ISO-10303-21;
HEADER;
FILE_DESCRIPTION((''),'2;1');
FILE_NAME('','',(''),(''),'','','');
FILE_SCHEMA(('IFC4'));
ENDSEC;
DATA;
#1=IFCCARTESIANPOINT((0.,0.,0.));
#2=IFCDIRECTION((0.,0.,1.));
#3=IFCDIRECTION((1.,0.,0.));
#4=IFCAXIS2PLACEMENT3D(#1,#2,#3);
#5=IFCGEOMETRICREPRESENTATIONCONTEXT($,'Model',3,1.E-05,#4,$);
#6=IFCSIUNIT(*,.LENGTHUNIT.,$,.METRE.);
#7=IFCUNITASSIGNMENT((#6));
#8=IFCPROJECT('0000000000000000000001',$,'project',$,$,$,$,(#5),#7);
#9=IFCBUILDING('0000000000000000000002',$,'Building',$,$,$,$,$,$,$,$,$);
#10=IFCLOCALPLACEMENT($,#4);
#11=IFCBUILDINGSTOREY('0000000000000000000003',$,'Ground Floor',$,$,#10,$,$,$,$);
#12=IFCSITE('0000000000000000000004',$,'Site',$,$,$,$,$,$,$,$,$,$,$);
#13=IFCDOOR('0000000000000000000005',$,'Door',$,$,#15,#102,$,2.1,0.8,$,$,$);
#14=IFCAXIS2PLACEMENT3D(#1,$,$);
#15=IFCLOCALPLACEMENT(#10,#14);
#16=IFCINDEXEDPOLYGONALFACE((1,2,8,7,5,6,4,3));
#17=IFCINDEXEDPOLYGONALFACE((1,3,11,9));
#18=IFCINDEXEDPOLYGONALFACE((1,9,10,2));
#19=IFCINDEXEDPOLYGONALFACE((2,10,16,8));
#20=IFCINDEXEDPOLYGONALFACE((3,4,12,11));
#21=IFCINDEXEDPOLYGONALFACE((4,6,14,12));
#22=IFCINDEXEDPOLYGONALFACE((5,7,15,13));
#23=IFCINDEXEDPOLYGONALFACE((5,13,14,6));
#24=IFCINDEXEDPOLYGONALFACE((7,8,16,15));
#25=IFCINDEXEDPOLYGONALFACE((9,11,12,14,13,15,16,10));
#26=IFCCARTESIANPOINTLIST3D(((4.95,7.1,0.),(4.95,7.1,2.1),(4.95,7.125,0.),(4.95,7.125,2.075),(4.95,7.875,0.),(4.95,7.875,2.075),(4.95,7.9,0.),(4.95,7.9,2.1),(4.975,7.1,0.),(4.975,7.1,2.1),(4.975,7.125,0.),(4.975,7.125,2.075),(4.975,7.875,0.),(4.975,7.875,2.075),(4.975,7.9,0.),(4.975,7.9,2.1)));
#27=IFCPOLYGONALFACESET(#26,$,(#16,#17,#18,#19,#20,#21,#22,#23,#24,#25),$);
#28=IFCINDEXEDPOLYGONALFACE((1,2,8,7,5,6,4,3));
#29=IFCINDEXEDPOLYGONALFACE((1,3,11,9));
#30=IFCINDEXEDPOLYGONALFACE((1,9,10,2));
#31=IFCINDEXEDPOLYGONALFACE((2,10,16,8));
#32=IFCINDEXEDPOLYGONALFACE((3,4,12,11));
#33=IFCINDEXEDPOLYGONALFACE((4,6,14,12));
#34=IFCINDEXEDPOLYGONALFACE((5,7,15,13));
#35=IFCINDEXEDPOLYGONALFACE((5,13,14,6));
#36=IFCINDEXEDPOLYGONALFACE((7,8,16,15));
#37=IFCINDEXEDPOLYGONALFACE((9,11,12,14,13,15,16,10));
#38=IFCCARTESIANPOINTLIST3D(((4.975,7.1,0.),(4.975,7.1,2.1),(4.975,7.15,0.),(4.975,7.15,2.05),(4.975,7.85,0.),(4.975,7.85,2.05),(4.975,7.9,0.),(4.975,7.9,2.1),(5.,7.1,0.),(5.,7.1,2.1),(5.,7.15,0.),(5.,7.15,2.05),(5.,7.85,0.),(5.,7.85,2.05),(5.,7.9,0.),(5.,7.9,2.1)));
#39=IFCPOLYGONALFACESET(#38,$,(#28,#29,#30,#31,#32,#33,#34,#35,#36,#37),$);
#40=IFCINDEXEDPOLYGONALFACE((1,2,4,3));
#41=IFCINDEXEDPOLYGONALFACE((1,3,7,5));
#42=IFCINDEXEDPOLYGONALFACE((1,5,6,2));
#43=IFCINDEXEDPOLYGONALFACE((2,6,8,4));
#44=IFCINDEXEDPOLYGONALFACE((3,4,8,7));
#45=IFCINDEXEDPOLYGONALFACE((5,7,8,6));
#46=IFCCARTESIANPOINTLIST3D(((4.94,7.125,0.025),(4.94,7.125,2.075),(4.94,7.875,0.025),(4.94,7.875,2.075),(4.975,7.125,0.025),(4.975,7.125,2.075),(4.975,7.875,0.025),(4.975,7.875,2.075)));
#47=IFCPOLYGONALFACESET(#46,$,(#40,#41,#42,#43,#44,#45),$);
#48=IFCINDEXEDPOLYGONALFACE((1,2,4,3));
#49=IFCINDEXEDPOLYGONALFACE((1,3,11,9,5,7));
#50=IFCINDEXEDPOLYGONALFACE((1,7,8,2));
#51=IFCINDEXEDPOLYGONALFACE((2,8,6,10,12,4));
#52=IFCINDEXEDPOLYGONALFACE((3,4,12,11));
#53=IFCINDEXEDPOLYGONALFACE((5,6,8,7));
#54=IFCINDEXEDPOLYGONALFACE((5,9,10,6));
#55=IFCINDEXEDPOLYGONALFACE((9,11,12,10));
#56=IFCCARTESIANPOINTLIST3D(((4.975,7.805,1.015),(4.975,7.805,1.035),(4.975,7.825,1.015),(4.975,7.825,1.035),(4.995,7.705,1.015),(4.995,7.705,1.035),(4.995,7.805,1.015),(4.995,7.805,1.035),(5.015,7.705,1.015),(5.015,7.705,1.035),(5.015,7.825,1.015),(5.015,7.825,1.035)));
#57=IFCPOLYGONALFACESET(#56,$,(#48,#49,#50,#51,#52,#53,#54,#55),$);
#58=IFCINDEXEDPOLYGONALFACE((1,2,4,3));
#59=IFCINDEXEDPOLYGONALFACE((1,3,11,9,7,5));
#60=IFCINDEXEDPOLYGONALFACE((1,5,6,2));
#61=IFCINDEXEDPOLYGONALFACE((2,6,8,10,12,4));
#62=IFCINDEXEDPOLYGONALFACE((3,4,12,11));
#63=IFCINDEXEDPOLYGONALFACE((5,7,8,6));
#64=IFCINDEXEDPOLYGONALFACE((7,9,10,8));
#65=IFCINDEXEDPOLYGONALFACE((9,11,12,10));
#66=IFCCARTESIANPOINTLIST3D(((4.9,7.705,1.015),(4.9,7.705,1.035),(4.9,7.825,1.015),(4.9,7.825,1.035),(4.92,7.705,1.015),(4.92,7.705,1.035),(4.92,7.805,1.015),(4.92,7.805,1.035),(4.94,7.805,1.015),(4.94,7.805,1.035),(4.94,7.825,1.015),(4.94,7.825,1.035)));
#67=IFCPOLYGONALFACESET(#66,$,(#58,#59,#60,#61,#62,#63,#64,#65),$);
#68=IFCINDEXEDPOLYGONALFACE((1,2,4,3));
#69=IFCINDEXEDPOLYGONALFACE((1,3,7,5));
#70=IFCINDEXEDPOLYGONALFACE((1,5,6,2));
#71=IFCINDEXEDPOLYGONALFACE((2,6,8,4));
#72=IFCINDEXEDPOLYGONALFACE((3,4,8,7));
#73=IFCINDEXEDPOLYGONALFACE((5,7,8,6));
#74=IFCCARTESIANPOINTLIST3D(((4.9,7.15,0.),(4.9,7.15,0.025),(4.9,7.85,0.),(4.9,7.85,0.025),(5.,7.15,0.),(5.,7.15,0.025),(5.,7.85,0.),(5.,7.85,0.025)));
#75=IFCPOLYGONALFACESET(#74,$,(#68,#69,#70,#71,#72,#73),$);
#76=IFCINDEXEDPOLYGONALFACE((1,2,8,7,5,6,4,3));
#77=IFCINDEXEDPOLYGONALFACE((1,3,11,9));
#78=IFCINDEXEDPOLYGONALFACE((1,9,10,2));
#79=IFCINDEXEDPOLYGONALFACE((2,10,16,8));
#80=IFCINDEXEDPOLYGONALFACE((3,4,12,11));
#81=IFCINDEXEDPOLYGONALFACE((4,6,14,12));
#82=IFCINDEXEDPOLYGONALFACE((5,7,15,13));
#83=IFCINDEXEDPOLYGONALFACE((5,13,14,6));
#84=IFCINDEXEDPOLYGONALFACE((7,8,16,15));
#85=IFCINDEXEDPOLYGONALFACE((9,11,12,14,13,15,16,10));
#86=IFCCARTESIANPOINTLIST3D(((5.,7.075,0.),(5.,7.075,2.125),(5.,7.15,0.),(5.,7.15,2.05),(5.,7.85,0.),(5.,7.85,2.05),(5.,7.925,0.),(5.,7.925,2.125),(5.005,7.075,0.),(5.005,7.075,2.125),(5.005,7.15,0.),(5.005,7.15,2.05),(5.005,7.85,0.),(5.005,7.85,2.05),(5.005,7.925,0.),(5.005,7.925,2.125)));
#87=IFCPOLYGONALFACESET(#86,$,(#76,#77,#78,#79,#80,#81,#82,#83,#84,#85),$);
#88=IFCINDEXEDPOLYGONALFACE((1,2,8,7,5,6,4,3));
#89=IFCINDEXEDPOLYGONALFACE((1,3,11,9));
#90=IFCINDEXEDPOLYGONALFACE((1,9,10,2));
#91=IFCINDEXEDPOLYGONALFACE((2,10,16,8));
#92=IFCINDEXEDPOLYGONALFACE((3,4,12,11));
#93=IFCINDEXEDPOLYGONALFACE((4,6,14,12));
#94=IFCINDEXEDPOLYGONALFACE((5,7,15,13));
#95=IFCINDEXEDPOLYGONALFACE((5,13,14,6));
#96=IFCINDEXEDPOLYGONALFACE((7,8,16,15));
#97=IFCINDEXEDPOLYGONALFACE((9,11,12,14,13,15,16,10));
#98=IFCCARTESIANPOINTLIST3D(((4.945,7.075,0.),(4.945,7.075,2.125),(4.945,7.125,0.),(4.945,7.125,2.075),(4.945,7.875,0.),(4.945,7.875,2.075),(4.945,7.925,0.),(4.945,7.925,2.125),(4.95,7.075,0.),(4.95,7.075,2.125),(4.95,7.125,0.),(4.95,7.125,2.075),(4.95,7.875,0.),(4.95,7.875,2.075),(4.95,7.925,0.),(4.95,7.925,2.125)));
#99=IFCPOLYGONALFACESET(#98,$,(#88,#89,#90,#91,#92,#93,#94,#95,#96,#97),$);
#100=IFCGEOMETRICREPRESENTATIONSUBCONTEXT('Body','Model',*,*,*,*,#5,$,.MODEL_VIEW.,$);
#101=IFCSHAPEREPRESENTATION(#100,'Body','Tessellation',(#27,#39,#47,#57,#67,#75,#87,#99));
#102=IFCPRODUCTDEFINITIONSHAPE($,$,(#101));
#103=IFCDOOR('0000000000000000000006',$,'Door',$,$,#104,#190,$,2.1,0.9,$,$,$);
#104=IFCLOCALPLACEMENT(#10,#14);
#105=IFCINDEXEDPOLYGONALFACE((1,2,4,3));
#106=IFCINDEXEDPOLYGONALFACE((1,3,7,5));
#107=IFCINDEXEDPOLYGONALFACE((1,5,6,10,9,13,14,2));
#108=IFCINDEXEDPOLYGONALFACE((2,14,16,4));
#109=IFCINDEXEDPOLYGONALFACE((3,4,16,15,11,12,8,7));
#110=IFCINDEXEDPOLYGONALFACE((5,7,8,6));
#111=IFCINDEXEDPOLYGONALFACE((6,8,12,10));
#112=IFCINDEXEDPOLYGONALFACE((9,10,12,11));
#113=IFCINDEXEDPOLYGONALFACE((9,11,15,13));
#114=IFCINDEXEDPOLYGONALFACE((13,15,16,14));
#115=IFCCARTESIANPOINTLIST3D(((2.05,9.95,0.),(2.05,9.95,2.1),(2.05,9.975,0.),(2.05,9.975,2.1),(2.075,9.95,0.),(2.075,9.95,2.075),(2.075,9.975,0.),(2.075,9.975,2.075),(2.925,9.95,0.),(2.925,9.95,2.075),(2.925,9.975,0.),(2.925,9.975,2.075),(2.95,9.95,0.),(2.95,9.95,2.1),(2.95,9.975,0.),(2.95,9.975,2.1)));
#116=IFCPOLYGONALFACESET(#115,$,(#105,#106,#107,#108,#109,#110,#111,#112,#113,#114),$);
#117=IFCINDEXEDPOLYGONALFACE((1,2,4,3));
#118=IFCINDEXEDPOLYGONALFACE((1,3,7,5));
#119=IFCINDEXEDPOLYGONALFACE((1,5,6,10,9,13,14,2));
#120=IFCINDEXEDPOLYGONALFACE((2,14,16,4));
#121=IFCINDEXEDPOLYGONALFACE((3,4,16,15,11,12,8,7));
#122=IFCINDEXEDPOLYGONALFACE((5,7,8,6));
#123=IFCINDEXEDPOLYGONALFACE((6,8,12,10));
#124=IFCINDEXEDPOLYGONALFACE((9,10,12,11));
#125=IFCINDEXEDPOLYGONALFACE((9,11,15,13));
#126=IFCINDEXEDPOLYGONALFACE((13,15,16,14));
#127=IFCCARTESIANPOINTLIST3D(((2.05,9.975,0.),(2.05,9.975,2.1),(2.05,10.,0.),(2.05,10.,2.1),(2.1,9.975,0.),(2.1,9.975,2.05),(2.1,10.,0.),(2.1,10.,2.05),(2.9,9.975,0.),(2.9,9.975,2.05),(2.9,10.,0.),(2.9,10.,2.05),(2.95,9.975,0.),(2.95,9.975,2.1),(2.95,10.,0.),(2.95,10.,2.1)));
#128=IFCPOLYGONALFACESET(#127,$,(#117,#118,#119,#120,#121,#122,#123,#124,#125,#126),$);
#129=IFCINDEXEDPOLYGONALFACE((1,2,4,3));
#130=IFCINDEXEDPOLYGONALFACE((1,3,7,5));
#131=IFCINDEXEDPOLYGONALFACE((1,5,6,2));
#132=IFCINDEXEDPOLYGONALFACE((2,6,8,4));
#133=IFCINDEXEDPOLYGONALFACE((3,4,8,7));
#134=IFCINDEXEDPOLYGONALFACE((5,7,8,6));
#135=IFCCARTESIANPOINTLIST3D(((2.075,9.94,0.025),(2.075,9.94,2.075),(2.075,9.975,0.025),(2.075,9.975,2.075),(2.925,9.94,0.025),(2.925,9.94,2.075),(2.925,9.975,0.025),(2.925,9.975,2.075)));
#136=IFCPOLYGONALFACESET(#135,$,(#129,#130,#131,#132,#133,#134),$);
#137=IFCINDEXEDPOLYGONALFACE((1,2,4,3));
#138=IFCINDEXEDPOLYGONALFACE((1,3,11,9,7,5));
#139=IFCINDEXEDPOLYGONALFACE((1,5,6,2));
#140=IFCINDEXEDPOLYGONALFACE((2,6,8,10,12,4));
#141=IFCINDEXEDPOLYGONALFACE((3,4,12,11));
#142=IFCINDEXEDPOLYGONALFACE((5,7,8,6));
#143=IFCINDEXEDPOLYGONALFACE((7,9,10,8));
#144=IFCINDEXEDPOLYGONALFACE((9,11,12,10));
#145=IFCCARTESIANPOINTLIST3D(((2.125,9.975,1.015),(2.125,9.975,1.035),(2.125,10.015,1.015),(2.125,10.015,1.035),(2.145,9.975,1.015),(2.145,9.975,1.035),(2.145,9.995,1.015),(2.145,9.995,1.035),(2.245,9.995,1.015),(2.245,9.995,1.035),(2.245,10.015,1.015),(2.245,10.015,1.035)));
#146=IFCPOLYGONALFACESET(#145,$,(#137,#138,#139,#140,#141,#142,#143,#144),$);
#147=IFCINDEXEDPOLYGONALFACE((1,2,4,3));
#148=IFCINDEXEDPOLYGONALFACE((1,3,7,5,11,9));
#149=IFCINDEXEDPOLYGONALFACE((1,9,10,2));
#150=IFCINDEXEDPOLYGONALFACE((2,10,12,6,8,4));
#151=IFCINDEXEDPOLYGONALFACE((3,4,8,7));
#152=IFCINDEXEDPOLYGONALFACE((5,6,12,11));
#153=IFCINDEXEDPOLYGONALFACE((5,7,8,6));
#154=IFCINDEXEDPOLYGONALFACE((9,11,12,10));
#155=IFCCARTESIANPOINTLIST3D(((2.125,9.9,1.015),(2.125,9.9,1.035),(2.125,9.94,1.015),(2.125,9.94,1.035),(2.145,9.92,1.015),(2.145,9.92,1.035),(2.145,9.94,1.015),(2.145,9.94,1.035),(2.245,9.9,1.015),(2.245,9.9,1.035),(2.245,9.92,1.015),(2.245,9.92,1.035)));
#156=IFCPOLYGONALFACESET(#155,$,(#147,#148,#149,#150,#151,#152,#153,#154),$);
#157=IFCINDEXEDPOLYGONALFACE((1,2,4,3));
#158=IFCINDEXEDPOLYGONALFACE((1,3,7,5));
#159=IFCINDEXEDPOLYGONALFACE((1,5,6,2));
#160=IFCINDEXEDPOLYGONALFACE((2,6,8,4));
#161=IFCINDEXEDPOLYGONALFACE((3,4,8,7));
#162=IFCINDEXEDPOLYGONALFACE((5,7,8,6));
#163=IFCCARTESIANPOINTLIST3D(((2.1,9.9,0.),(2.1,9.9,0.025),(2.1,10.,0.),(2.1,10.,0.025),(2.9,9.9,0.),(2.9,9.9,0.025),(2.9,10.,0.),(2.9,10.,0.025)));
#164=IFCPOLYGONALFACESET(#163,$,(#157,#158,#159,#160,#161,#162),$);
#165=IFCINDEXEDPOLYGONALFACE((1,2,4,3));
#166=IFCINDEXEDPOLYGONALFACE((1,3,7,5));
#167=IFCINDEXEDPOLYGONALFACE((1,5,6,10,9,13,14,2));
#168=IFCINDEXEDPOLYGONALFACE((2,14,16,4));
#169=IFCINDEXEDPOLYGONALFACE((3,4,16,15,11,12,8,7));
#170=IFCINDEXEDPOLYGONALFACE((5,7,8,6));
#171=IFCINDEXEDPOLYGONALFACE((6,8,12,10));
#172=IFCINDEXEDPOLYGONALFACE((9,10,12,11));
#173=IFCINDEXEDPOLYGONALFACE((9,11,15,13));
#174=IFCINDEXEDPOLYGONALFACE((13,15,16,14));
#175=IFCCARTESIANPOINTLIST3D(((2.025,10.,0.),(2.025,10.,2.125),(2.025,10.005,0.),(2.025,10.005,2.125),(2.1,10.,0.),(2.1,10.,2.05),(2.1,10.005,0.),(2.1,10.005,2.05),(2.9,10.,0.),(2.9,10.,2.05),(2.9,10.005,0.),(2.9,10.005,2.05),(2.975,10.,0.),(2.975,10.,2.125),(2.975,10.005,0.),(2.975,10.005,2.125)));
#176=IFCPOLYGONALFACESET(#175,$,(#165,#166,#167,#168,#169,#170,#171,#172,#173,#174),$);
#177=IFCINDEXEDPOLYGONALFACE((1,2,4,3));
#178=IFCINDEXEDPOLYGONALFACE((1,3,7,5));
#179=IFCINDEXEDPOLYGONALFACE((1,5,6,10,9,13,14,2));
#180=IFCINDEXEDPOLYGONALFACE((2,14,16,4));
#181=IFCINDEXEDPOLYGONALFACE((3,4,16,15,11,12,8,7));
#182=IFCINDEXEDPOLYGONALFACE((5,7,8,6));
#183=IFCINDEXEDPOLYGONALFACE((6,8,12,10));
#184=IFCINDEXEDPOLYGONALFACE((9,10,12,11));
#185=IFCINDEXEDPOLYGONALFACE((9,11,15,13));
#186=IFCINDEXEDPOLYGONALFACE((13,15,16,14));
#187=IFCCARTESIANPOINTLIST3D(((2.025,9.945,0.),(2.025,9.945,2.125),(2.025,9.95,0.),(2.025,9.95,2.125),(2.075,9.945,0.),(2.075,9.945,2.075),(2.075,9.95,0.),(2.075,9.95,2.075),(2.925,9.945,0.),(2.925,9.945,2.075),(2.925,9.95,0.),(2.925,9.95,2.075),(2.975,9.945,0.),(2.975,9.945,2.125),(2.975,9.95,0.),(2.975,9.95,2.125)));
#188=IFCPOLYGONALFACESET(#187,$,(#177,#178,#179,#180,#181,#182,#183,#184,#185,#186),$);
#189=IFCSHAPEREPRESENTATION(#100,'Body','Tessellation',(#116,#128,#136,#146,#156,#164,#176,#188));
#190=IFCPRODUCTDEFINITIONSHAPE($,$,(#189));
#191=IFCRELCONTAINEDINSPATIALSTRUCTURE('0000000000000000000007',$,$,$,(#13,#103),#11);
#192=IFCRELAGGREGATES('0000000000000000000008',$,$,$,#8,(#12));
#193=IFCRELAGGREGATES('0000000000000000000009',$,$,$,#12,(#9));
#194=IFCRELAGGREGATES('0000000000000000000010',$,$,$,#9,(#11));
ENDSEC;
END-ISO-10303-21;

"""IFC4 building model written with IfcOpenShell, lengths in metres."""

from ifc_helpers import new_model, si_unit, frame, origin_with_axes, place, context, subcontext, project, spatial, line, indexed_curve, outline, extrude, element, save


model = new_model("IFC4")

# Units and contexts
model_context = context("Model", 3, precision=1e-05, world=origin_with_axes())
body_context = subcontext(model_context, "Body", "Model", "MODEL_VIEW")
ifc_project = project(units=[si_unit("LENGTHUNIT", "METRE")], contexts=[model_context])

# Site, building, storey
site = spatial("IfcSite", under=ifc_project, Name="Site")
building = spatial("IfcBuilding", under=site, Name="Building")
storey_placement = place(None, origin_with_axes())
storey = spatial("IfcBuildingStorey", under=building, at=storey_placement, Name="Ground Floor")

# Doors
door_1_placement = place(storey_placement, frame((5.0, 7.1, 0.0), z_axis=(0.0, 0.0, 1.0), x_axis=(0.0, 1.0, 0.0)))
element("IfcDoor", 1, at=door_1_placement, inside=storey, Name="Door", OverallHeight=2.1, OverallWidth=0.8, context=body_context, shape_type="SweptSolid", body=[
    extrude(outline(indexed_curve([(0.0, 0.0), (0.0, 2.1), (0.8, 2.1), (0.8, 0.0), (0.775, 0.0), (0.775, 2.075), (0.025, 2.075), (0.025, 0.0)], segments=[line(1, 2, 3, 4, 5, 6, 7, 8, 1)])), frame((0.0, 0.025, 0.0), z_axis=(0.0, -1.0, 0.0), x_axis=(1.0, 0.0, 0.0)), (0.0, 0.0, -1.0), 0.025),
    extrude(outline(indexed_curve([(0.0, 0.0), (0.0, 2.1), (0.8, 2.1), (0.8, 0.0), (0.75, 0.0), (0.75, 2.05), (0.05, 2.05), (0.05, 0.0)], segments=[line(1, 2, 3, 4, 5, 6, 7, 8, 1)])), frame((0.0, 0.0, 0.0), z_axis=(0.0, -1.0, 0.0), x_axis=(1.0, 0.0, 0.0)), (0.0, 0.0, -1.0), 0.025),
    extrude(outline(indexed_curve([(0.0, 0.0), (0.75, 0.0), (0.75, 0.035), (0.0, 0.035)], segments=[line(1, 2, 3, 4, 1)])), frame((0.025, 0.025, 0.025), z_axis=(0.0, 0.0, 1.0), x_axis=(1.0, 0.0, 0.0)), (0.0, 0.0, 1.0), 2.05),
    extrude(outline(indexed_curve([(0.0, 0.0), (0.0, -0.04), (-0.12, -0.04), (-0.12, -0.02), (-0.02, -0.02), (-0.02, 0.0)], segments=[line(1, 2, 3, 4, 5, 6, 1)])), frame((0.725, 0.025, 1.015), z_axis=(0.0, 0.0, 1.0), x_axis=(1.0, 0.0, 0.0)), (0.0, 0.0, 1.0), 0.02),
    extrude(outline(indexed_curve([(0.0, 0.0), (0.0, 0.04), (-0.12, 0.04), (-0.12, 0.02), (-0.02, 0.02), (-0.02, 0.0)], segments=[line(1, 2, 3, 4, 5, 6, 1)])), frame((0.725, 0.06, 1.015), z_axis=(0.0, 0.0, 1.0), x_axis=(1.0, 0.0, 0.0)), (0.0, 0.0, 1.0), 0.02),
    extrude(outline(indexed_curve([(0.0, 0.0), (0.7, 0.0), (0.7, 0.1), (0.0, 0.1)], segments=[line(1, 2, 3, 4, 1)])), frame((0.05, 0.0, 0.0), z_axis=(0.0, 0.0, 1.0), x_axis=(1.0, 0.0, 0.0)), (0.0, 0.0, 1.0), 0.025),
    extrude(outline(indexed_curve([(0.0, 0.0), (0.0, 2.125), (0.85, 2.125), (0.85, 0.0), (0.775, 0.0), (0.775, 2.05), (0.075, 2.05), (0.075, 0.0)], segments=[line(1, 2, 3, 4, 5, 6, 7, 8, 1)])), frame((-0.025, -0.005, 0.0), z_axis=(0.0, -1.0, 0.0), x_axis=(1.0, 0.0, 0.0)), (0.0, 0.0, -1.0), 0.005),
    extrude(outline(indexed_curve([(0.0, 0.0), (0.0, 2.125), (0.85, 2.125), (0.85, 0.0), (0.8, 0.0), (0.8, 2.075), (0.05, 2.075), (0.05, 0.0)], segments=[line(1, 2, 3, 4, 5, 6, 7, 8, 1)])), frame((-0.025, 0.05, 0.0), z_axis=(0.0, -1.0, 0.0), x_axis=(1.0, 0.0, 0.0)), (0.0, 0.0, -1.0), 0.005),
])
door_2_placement = place(storey_placement, frame((2.95, 10.0, 0.0), z_axis=(0.0, 0.0, 1.0), x_axis=(-1.0, 0.0, 0.0)))
element("IfcDoor", 2, at=door_2_placement, inside=storey, Name="Door", OverallHeight=2.1, OverallWidth=0.9, context=body_context, shape_type="SweptSolid", body=[
    extrude(outline(indexed_curve([(0.0, 0.0), (0.0, 2.1), (0.9, 2.1), (0.9, 0.0), (0.875, 0.0), (0.875, 2.075), (0.025, 2.075), (0.025, 0.0)], segments=[line(1, 2, 3, 4, 5, 6, 7, 8, 1)])), frame((0.0, 0.025, 0.0), z_axis=(0.0, -1.0, 0.0), x_axis=(1.0, 0.0, 0.0)), (0.0, 0.0, -1.0), 0.025),
    extrude(outline(indexed_curve([(0.0, 0.0), (0.0, 2.1), (0.9, 2.1), (0.9, 0.0), (0.85, 0.0), (0.85, 2.05), (0.05, 2.05), (0.05, 0.0)], segments=[line(1, 2, 3, 4, 5, 6, 7, 8, 1)])), frame((0.0, 0.0, 0.0), z_axis=(0.0, -1.0, 0.0), x_axis=(1.0, 0.0, 0.0)), (0.0, 0.0, -1.0), 0.025),
    extrude(outline(indexed_curve([(0.0, 0.0), (0.85, 0.0), (0.85, 0.035), (0.0, 0.035)], segments=[line(1, 2, 3, 4, 1)])), frame((0.025, 0.025, 0.025), z_axis=(0.0, 0.0, 1.0), x_axis=(1.0, 0.0, 0.0)), (0.0, 0.0, 1.0), 2.05),
    extrude(outline(indexed_curve([(0.0, 0.0), (0.0, -0.04), (-0.12, -0.04), (-0.12, -0.02), (-0.02, -0.02), (-0.02, 0.0)], segments=[line(1, 2, 3, 4, 5, 6, 1)])), frame((0.825, 0.025, 1.015), z_axis=(0.0, 0.0, 1.0), x_axis=(1.0, 0.0, 0.0)), (0.0, 0.0, 1.0), 0.02),
    extrude(outline(indexed_curve([(0.0, 0.0), (0.0, 0.04), (-0.12, 0.04), (-0.12, 0.02), (-0.02, 0.02), (-0.02, 0.0)], segments=[line(1, 2, 3, 4, 5, 6, 1)])), frame((0.825, 0.06, 1.015), z_axis=(0.0, 0.0, 1.0), x_axis=(1.0, 0.0, 0.0)), (0.0, 0.0, 1.0), 0.02),
    extrude(outline(indexed_curve([(0.0, 0.0), (0.8, 0.0), (0.8, 0.1), (0.0, 0.1)], segments=[line(1, 2, 3, 4, 1)])), frame((0.05, 0.0, 0.0), z_axis=(0.0, 0.0, 1.0), x_axis=(1.0, 0.0, 0.0)), (0.0, 0.0, 1.0), 0.025),
    extrude(outline(indexed_curve([(0.0, 0.0), (0.0, 2.125), (0.95, 2.125), (0.95, 0.0), (0.875, 0.0), (0.875, 2.05), (0.075, 2.05), (0.075, 0.0)], segments=[line(1, 2, 3, 4, 5, 6, 7, 8, 1)])), frame((-0.025, -0.005, 0.0), z_axis=(0.0, -1.0, 0.0), x_axis=(1.0, 0.0, 0.0)), (0.0, 0.0, -1.0), 0.005),
    extrude(outline(indexed_curve([(0.0, 0.0), (0.0, 2.125), (0.95, 2.125), (0.95, 0.0), (0.9, 0.0), (0.9, 2.075), (0.05, 2.075), (0.05, 0.0)], segments=[line(1, 2, 3, 4, 5, 6, 7, 8, 1)])), frame((-0.025, 0.05, 0.0), z_axis=(0.0, -1.0, 0.0), x_axis=(1.0, 0.0, 0.0)), (0.0, 0.0, -1.0), 0.005),
])

save(model, "model.ifc")
